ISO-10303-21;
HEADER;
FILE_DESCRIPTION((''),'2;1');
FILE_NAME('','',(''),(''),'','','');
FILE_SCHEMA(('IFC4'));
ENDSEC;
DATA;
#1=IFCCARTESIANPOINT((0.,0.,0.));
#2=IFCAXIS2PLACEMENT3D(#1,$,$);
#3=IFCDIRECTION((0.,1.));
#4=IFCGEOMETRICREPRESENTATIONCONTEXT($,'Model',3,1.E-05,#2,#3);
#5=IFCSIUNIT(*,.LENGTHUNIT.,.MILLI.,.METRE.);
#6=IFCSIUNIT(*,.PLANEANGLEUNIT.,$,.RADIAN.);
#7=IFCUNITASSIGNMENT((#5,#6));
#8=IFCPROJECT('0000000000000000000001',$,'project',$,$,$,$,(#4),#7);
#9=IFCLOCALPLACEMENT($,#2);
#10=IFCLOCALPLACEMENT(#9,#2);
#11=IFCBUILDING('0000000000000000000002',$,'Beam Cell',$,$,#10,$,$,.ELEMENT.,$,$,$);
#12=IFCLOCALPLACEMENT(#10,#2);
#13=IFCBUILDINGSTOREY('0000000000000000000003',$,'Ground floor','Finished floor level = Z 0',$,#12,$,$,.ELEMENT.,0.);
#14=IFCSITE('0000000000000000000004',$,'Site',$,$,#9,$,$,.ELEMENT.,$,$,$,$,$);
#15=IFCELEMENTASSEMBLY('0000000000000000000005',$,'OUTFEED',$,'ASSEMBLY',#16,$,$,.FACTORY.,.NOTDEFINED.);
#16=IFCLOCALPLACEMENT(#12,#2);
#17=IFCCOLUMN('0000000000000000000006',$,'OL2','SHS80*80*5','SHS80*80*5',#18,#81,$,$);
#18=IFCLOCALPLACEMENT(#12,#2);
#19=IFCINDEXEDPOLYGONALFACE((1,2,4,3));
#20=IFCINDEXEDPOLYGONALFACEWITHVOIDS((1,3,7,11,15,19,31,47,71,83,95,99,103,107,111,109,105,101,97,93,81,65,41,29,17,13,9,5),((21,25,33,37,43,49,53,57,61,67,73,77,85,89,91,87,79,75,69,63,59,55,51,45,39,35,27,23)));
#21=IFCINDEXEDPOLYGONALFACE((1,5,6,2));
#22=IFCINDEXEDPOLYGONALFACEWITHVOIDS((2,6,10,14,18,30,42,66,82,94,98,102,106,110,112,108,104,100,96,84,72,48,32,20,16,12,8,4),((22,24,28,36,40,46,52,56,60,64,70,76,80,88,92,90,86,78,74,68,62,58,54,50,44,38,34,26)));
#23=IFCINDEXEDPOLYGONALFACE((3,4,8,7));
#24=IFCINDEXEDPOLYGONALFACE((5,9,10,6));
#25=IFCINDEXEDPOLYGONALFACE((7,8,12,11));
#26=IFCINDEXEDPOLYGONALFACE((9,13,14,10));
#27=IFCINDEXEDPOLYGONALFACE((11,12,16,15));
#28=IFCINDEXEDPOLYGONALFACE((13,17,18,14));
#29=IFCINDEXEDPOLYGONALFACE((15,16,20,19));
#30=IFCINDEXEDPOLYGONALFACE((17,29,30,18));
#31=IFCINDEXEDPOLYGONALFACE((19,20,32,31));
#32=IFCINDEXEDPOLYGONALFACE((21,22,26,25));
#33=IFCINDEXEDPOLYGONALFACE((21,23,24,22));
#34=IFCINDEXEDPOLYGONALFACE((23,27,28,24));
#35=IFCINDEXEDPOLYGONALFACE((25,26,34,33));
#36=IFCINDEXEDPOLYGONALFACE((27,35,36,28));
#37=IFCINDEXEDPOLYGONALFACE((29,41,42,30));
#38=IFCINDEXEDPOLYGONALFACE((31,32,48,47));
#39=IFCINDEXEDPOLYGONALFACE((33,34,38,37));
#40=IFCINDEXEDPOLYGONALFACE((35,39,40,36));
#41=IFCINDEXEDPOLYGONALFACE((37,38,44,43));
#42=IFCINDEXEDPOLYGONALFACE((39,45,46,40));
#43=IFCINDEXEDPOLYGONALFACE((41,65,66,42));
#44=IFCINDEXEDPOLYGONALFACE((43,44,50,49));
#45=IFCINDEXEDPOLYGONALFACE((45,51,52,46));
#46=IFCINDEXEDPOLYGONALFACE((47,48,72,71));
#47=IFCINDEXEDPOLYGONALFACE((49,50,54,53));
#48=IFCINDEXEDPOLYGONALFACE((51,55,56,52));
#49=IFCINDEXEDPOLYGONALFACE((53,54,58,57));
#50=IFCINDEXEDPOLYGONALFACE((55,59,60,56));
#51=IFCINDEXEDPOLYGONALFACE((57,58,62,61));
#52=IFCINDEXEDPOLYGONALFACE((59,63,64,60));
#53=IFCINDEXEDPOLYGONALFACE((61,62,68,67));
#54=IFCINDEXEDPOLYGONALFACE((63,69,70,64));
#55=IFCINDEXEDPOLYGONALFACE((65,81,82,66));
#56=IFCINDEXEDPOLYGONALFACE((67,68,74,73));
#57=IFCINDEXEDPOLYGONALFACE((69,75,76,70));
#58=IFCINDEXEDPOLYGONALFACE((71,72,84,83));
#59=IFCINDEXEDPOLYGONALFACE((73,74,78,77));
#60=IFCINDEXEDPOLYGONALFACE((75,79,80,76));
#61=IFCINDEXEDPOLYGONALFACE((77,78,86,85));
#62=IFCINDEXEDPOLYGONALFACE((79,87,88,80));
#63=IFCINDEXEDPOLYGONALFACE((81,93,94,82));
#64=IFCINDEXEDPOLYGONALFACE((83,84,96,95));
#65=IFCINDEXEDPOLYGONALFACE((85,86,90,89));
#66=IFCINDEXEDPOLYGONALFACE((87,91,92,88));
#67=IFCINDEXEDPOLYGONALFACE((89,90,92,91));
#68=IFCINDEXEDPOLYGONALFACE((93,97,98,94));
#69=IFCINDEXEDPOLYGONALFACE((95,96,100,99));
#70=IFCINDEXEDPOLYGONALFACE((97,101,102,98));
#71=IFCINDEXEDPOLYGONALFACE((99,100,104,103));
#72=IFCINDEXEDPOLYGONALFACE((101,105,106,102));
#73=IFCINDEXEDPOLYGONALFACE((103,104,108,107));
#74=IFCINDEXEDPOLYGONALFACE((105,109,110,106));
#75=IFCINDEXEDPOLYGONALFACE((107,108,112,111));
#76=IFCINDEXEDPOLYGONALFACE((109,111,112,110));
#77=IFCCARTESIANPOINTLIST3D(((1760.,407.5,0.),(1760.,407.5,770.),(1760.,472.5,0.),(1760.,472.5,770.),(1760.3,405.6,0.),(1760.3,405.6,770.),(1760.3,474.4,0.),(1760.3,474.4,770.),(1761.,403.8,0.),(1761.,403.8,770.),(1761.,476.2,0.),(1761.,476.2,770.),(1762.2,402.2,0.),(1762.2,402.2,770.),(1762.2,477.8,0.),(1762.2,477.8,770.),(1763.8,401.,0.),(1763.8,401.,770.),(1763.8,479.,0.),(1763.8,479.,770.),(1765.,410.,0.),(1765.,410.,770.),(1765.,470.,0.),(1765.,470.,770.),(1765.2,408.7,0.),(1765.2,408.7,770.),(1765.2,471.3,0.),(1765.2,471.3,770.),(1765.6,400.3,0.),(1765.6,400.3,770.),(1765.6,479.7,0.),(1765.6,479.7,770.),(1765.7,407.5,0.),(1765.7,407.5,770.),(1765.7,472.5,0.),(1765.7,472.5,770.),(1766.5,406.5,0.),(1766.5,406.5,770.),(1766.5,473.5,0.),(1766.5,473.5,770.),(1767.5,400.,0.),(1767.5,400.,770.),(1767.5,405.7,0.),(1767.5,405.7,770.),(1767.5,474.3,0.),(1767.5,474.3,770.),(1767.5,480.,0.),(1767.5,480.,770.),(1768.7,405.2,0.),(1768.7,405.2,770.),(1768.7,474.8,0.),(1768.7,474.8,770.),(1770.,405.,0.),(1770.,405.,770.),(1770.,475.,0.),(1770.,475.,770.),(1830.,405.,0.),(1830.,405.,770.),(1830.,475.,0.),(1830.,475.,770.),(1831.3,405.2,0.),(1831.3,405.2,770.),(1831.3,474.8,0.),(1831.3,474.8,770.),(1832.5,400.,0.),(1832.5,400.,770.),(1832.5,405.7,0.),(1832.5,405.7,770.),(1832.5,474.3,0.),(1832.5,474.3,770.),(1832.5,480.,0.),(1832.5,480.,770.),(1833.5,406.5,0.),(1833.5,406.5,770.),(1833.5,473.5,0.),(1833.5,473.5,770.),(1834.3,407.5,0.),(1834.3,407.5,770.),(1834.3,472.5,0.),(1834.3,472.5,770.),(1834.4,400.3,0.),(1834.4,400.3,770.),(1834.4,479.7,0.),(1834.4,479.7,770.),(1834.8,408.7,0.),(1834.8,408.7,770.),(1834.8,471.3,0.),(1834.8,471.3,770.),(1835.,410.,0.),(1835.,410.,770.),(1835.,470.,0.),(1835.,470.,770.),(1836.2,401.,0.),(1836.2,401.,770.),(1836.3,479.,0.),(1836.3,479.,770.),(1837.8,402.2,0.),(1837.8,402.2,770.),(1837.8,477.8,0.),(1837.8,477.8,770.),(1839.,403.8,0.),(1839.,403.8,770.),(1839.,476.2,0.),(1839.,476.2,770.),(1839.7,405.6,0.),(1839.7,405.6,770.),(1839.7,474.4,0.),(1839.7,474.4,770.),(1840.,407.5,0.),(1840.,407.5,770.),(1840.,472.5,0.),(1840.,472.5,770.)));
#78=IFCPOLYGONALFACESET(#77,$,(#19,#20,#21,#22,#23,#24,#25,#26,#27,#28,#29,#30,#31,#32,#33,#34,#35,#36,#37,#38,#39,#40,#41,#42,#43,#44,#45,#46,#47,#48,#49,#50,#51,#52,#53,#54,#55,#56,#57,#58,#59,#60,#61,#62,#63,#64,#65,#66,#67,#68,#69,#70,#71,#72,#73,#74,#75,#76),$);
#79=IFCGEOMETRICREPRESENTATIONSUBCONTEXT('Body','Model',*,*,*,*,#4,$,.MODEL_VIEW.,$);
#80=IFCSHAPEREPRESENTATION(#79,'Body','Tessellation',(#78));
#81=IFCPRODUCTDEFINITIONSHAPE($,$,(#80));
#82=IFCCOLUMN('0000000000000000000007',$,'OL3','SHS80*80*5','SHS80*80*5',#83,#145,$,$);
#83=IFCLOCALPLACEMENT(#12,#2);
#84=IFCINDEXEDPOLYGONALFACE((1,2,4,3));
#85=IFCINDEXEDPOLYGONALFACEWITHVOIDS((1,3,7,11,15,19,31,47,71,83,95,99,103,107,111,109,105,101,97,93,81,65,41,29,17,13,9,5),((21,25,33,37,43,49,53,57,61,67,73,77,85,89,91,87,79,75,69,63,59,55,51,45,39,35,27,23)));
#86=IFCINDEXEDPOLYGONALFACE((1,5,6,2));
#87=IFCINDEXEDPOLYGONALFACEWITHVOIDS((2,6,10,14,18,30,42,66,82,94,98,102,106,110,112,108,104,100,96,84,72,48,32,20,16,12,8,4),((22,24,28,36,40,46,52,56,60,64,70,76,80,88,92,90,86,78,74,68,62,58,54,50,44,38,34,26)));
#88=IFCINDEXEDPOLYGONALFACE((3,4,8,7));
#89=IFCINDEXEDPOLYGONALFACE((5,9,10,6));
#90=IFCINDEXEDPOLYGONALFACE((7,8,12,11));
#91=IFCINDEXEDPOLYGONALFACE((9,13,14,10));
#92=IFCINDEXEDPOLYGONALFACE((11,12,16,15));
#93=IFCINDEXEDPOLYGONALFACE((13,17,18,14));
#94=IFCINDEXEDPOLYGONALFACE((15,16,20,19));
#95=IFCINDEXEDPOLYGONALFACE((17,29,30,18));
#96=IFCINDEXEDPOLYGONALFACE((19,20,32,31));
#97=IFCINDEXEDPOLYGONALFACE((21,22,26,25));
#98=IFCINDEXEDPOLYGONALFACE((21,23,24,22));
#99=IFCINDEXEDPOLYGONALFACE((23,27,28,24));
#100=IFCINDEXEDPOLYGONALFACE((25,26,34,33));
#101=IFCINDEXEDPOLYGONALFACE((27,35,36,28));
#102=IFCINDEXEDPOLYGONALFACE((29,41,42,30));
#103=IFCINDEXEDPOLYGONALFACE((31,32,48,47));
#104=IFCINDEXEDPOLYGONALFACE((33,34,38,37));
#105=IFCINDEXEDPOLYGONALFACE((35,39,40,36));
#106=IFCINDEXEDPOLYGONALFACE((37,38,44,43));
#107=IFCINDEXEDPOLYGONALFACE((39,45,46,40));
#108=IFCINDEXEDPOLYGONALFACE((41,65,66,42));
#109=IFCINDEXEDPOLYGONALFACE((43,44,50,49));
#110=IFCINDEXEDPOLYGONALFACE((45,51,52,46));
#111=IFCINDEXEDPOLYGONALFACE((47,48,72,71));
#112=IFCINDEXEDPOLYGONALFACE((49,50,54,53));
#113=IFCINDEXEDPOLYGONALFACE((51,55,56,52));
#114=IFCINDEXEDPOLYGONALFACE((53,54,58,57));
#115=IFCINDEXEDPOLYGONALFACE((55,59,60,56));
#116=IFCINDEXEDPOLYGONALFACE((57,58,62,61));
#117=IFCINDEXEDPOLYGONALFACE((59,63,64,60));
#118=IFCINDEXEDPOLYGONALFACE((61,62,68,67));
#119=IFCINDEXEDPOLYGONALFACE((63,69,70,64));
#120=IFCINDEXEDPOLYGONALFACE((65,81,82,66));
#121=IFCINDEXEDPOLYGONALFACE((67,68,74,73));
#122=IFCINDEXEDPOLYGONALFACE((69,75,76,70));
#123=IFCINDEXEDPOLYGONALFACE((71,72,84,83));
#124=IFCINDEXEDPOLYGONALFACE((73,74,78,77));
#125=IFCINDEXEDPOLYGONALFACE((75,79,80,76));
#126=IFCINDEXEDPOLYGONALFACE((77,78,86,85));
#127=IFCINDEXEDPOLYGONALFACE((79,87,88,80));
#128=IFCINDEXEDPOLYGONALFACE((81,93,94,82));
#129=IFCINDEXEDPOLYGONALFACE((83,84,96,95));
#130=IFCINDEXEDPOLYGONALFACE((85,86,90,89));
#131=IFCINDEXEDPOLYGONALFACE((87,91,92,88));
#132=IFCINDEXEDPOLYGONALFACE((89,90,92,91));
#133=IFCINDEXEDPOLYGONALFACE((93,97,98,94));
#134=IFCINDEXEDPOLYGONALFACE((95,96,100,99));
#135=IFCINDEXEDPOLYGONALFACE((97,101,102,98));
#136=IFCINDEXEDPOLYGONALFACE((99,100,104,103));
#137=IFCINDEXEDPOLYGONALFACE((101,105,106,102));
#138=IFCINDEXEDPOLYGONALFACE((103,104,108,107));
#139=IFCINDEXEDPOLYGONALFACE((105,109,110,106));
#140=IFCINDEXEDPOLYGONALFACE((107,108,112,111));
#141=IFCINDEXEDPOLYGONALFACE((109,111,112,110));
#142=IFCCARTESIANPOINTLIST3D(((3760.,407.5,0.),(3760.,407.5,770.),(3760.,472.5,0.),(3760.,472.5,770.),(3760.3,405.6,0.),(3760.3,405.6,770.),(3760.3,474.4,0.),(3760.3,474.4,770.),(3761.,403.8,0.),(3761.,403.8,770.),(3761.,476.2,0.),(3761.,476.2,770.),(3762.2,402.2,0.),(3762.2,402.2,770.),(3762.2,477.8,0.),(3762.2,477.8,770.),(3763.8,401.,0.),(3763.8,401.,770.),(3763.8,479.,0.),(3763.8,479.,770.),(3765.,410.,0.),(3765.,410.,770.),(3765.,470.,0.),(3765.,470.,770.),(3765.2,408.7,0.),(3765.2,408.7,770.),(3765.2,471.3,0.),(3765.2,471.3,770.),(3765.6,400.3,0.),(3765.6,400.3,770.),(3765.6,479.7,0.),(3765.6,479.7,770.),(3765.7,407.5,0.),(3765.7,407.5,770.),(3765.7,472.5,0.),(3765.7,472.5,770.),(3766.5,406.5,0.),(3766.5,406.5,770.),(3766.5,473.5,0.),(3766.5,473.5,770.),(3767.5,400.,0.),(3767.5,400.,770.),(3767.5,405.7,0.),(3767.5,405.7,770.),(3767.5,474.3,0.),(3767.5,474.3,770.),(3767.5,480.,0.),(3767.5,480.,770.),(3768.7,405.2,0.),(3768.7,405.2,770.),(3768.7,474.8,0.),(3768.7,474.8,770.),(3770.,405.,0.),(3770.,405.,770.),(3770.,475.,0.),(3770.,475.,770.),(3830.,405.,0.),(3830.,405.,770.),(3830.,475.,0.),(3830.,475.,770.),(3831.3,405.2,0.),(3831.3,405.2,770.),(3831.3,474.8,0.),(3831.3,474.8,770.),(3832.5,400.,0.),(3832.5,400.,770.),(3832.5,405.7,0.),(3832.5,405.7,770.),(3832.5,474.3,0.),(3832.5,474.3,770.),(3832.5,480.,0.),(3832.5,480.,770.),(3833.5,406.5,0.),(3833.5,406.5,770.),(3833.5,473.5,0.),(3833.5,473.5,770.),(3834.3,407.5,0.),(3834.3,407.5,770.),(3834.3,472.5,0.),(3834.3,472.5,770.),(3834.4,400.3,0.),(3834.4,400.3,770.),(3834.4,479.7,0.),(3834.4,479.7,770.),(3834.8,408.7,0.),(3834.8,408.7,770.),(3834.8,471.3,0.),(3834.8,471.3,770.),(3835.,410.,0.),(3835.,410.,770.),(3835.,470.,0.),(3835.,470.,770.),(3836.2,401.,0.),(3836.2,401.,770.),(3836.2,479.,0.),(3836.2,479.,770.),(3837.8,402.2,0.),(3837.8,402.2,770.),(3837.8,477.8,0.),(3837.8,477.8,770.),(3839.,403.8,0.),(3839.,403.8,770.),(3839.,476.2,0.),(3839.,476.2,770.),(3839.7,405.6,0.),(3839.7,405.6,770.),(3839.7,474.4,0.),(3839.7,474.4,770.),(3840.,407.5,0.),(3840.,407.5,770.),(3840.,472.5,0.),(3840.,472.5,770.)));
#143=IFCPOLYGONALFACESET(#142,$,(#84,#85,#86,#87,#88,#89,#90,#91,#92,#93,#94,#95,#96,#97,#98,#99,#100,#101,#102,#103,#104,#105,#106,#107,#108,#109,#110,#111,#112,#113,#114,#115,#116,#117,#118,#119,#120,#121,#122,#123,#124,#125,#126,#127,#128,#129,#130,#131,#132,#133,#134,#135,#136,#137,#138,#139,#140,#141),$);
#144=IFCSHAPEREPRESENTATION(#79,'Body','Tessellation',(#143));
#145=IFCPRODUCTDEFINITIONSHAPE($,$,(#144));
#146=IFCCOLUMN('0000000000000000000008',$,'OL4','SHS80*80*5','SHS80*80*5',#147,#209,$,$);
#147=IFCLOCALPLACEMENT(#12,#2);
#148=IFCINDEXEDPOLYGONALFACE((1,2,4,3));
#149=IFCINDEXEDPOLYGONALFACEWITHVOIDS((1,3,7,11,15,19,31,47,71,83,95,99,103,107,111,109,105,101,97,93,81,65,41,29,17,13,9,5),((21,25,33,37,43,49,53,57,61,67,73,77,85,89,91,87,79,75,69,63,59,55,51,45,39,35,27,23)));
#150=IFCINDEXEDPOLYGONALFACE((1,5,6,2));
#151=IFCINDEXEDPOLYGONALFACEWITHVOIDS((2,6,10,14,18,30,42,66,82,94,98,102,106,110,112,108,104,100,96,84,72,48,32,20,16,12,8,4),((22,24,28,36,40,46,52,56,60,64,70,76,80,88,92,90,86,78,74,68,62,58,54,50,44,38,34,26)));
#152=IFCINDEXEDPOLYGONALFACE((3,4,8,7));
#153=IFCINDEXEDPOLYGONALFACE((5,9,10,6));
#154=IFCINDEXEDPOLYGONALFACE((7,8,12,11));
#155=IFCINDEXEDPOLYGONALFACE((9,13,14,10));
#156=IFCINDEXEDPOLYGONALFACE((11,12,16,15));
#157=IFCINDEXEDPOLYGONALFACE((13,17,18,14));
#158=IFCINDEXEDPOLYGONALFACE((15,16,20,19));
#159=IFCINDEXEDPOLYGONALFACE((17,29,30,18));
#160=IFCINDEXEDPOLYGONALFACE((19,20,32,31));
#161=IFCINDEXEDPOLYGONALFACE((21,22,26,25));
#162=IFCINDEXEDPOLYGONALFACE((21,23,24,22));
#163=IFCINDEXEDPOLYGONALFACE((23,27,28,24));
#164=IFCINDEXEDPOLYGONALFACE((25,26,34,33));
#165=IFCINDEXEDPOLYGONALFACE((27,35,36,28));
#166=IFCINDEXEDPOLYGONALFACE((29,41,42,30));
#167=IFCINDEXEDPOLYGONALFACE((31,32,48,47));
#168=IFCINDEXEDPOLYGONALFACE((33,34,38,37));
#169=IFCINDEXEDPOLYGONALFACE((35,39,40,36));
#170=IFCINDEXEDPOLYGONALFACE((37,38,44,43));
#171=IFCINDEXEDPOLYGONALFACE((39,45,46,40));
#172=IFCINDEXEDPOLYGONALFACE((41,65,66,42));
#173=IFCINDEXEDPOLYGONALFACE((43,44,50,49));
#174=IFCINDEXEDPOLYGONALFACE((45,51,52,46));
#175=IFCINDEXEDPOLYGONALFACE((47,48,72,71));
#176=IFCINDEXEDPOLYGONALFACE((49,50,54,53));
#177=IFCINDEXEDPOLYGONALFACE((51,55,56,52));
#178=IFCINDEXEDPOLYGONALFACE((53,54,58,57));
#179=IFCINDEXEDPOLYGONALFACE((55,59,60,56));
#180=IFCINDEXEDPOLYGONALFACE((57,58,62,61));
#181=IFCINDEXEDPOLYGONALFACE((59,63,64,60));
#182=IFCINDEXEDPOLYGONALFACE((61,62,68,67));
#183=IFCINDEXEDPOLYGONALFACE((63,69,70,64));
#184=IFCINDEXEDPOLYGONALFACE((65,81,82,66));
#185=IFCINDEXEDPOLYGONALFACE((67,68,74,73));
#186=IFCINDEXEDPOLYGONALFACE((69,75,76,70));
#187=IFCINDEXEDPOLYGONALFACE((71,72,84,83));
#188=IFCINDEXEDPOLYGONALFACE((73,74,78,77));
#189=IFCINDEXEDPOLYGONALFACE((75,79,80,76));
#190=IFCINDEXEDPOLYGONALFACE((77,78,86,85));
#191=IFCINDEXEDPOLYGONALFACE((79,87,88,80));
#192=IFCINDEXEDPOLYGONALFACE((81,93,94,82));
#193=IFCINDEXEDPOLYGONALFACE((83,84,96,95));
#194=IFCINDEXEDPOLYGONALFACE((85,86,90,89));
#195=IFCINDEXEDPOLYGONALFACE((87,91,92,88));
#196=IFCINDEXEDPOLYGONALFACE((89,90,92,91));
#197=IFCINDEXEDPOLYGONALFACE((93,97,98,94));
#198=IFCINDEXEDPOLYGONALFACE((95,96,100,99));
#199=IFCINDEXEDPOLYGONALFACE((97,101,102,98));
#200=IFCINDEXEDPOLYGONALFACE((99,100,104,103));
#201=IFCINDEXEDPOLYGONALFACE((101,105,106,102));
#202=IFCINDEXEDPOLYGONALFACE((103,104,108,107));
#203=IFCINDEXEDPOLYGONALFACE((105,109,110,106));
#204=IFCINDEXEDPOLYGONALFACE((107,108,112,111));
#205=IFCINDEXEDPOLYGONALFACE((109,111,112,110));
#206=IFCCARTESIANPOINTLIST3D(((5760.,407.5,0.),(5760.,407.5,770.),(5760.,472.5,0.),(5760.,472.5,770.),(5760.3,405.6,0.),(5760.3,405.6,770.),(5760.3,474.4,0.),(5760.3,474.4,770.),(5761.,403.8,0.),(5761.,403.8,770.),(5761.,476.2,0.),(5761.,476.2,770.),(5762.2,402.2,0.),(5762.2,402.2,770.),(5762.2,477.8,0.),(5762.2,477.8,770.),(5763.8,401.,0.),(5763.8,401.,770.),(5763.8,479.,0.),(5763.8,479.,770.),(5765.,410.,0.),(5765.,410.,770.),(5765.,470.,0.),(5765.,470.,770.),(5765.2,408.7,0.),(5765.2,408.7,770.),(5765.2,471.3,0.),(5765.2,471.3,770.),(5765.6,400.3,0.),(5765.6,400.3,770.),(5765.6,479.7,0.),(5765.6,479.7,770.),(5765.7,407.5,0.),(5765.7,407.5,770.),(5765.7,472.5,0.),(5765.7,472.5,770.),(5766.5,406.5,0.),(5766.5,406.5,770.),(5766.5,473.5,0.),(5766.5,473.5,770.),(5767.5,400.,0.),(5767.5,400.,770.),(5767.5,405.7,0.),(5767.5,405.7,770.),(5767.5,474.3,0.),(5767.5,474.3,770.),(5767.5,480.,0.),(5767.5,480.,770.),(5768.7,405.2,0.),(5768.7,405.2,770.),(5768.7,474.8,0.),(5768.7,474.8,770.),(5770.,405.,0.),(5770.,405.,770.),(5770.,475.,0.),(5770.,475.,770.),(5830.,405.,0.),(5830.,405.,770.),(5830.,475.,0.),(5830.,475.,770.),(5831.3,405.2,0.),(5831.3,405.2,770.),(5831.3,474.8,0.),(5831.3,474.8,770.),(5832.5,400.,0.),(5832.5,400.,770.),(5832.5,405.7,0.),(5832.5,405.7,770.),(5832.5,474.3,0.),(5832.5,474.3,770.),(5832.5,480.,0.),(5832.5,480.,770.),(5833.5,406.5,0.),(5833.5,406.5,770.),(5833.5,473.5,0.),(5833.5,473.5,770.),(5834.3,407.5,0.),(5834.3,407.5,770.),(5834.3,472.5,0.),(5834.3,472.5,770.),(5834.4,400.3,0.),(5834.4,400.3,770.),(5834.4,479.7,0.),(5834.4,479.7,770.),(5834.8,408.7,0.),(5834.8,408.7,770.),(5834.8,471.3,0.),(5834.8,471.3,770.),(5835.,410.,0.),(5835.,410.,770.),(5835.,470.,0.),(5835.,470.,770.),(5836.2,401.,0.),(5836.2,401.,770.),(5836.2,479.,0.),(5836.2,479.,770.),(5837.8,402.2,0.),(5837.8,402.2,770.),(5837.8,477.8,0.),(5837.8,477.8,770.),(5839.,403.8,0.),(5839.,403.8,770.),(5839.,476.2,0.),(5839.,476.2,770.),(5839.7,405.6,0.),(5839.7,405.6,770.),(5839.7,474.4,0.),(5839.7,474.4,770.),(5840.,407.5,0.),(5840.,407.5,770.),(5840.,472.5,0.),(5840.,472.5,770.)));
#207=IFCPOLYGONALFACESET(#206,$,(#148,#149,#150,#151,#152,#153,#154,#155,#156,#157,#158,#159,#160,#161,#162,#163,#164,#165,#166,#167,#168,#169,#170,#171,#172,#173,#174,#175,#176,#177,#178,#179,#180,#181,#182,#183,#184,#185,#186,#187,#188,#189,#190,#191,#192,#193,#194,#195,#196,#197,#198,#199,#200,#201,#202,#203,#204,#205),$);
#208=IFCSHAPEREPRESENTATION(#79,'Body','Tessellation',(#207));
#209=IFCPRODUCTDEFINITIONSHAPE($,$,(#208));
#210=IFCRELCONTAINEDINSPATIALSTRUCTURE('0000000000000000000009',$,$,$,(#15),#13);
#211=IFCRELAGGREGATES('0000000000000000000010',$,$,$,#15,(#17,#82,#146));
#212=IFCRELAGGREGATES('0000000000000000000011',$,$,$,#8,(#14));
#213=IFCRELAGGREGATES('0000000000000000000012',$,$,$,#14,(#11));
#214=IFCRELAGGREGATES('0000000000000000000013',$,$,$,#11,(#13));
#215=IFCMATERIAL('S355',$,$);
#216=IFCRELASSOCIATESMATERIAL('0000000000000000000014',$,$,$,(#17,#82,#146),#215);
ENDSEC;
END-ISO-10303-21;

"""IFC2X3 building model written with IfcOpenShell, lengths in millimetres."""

from ifc_helpers import new_model, si_unit, direction, frame, origin, origin_2d, place, context, subcontext, project, spatial, hollow_rectangle, extrude, material, element, aggregate, save


model = new_model("IFC2X3")

# Units and contexts
model_context = context("Model", 3, precision=1e-05, world=origin(), true_north=direction((0.0, 1.0)))
body_context = subcontext(model_context, "Body", "Model", "MODEL_VIEW")
ifc_project = project(units=[si_unit("LENGTHUNIT", "METRE", prefix="MILLI"), si_unit("PLANEANGLEUNIT", "RADIAN")], contexts=[model_context])

# Site, building, storey
site_placement = place(None, origin())
site = spatial("IfcSite", under=ifc_project, at=site_placement, Name="Site", CompositionType="ELEMENT")
building_placement = place(site_placement, origin())
building = spatial("IfcBuilding", under=site, at=building_placement, Name="Beam Cell", CompositionType="ELEMENT")
storey_placement = place(building_placement, origin())
storey = spatial("IfcBuildingStorey", under=building, at=storey_placement, Name="Ground floor", Description="Finished floor level = Z 0", CompositionType="ELEMENT", Elevation=0.0)

# Element assembly, columns
ifc_material = material(Name="S355")
assembly_1_placement = place(storey_placement, origin())
assembly_1 = element("IfcElementAssembly", 1, at=assembly_1_placement, inside=storey, Name="OUTFEED", ObjectType="ASSEMBLY", AssemblyPlace="FACTORY", PredefinedType="NOTDEFINED")
column_1_placement = place(storey_placement, frame((1800.0, 440.0, 0.0), z_axis=(0.0, 0.0, 1.0), x_axis=(1.0, 0.0, 0.0)))
column_1 = element("IfcColumn", 2, at=column_1_placement, material=ifc_material, Name="OL2", Description="SHS80*80*5", ObjectType="SHS80*80*5", context=body_context, shape_type="SweptSolid", body=[
    extrude(hollow_rectangle(XDim=80.0, YDim=80.0, WallThickness=5.0, InnerFilletRadius=5.0, OuterFilletRadius=7.5, at=origin_2d()), origin(), (0.0, 0.0, 1.0), 770.0),
])
column_2_placement = place(storey_placement, frame((3800.0, 440.0, 0.0), z_axis=(0.0, 0.0, 1.0), x_axis=(1.0, 0.0, 0.0)))
column_2 = element("IfcColumn", 3, at=column_2_placement, material=ifc_material, Name="OL3", Description="SHS80*80*5", ObjectType="SHS80*80*5", context=body_context, shape_type="SweptSolid", body=[
    extrude(hollow_rectangle(XDim=80.0, YDim=80.0, WallThickness=5.0, InnerFilletRadius=5.0, OuterFilletRadius=7.5, at=origin_2d()), origin(), (0.0, 0.0, 1.0), 770.0),
])
column_3_placement = place(storey_placement, frame((5800.0, 440.0, 0.0), z_axis=(0.0, 0.0, 1.0), x_axis=(1.0, 0.0, 0.0)))
column_3 = element("IfcColumn", 4, at=column_3_placement, material=ifc_material, Name="OL4", Description="SHS80*80*5", ObjectType="SHS80*80*5", context=body_context, shape_type="SweptSolid", body=[
    extrude(hollow_rectangle(XDim=80.0, YDim=80.0, WallThickness=5.0, InnerFilletRadius=5.0, OuterFilletRadius=7.5, at=origin_2d()), origin(), (0.0, 0.0, 1.0), 770.0),
])
aggregate(assembly_1, [column_1, column_2, column_3])

save(model, "model.ifc")
